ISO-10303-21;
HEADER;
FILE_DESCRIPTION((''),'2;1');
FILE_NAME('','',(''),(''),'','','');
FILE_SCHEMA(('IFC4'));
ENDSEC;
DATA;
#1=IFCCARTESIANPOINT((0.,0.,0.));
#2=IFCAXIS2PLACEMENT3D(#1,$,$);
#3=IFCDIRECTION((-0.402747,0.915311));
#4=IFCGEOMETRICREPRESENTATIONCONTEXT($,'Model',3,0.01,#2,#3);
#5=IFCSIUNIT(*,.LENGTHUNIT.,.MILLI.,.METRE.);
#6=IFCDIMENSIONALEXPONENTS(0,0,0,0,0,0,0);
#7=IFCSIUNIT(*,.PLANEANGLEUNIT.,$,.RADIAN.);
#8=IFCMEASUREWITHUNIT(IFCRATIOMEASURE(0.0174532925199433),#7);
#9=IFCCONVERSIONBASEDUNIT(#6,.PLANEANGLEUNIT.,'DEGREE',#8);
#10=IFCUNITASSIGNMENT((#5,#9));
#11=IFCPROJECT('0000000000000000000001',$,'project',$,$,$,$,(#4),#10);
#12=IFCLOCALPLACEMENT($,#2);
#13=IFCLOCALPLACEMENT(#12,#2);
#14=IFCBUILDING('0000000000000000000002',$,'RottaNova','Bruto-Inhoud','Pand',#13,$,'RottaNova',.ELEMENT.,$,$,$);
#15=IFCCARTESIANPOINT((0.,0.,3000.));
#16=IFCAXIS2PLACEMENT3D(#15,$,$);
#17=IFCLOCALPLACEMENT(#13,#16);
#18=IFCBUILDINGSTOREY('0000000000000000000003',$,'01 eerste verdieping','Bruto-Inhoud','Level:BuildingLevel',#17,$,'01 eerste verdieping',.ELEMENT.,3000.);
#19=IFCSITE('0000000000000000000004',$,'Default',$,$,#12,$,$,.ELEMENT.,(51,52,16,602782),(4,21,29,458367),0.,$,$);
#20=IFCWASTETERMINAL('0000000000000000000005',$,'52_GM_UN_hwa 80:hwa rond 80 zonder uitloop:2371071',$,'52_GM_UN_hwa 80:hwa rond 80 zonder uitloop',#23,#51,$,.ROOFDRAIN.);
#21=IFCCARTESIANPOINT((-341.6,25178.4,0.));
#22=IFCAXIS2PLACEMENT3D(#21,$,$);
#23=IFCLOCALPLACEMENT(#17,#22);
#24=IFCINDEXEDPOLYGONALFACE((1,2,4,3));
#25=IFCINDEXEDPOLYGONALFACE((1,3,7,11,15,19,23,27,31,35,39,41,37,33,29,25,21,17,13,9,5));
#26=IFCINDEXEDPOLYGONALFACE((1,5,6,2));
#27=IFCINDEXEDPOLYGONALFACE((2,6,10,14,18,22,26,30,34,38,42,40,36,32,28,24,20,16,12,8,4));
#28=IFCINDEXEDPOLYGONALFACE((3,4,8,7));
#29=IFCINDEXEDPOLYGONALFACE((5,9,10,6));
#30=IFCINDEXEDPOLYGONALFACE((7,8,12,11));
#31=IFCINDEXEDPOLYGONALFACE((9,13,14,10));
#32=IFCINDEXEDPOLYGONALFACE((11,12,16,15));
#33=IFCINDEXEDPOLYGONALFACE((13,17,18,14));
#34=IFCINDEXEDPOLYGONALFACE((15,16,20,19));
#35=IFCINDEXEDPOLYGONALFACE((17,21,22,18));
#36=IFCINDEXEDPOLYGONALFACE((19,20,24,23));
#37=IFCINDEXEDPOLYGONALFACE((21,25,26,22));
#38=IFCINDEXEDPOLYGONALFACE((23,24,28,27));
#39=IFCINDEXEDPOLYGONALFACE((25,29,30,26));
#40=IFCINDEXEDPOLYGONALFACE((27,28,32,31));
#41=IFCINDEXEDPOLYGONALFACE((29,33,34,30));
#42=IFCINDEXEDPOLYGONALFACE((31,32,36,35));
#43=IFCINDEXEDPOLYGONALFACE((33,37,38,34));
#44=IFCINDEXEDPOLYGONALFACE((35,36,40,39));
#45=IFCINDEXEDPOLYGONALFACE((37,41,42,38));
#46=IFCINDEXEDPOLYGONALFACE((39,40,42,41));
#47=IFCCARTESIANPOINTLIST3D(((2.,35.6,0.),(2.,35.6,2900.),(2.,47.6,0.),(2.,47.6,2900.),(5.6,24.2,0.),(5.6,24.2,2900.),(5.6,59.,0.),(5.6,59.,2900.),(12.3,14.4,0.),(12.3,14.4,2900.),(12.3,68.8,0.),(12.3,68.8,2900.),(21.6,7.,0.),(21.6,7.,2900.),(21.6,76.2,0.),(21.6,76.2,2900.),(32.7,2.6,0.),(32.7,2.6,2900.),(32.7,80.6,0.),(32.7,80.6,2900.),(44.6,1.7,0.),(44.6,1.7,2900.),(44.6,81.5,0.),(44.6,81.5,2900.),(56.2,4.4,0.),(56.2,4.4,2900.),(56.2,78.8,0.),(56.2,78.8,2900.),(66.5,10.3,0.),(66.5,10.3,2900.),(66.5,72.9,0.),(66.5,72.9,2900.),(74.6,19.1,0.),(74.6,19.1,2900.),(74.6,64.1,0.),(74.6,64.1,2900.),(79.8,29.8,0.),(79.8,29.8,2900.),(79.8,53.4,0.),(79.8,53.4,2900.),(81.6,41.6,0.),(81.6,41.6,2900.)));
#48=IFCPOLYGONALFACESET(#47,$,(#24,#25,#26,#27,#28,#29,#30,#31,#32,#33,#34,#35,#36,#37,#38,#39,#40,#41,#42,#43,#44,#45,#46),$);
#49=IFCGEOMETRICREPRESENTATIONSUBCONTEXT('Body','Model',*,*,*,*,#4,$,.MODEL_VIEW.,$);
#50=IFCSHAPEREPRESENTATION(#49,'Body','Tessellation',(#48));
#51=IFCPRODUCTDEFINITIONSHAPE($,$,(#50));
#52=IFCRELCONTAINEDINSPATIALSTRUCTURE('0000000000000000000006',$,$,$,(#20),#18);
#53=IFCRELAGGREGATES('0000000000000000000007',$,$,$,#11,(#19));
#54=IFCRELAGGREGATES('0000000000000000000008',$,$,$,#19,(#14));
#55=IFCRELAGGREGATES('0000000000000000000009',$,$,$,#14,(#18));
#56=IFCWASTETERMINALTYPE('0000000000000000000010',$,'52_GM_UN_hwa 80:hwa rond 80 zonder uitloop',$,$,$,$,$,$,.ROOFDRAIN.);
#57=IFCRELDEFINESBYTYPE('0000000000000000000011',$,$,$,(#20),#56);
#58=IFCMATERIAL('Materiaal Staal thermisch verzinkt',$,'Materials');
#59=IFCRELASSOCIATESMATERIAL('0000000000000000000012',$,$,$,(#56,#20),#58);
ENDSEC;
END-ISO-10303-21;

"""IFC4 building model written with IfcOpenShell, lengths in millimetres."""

from ifc_helpers import new_model, entity, si_unit, converted_unit, direction, frame, frame_2d, origin, place, context, subcontext, project, spatial, circle, extrude, source, transform, mapped, material, type_object, type_shapes, element, save


model = new_model("IFC4")

# Units and contexts
model_context = context("Model", 3, precision=0.01, world=origin(), true_north=direction((-0.402747, 0.915311)))
body_context = subcontext(model_context, "Body", "Model", "MODEL_VIEW")
ifc_project = project(units=[si_unit("LENGTHUNIT", "METRE", prefix="MILLI"), converted_unit("PLANEANGLEUNIT", "DEGREE", entity("IfcRatioMeasure", 0.0174532925199433), si_unit("PLANEANGLEUNIT", "RADIAN"), dimensions=[0, 0, 0, 0, 0, 0, 0])], contexts=[model_context])

# Site, building, storey
site_placement = place(None, origin())
site = spatial("IfcSite", under=ifc_project, at=site_placement, Name="Default", CompositionType="ELEMENT", RefLatitude=(51, 52, 16, 602782), RefLongitude=(4, 21, 29, 458367), RefElevation=0.0)
building_placement = place(site_placement, origin())
building = spatial("IfcBuilding", under=site, at=building_placement, Name="RottaNova", Description="Bruto-Inhoud", ObjectType="Pand", LongName="RottaNova", CompositionType="ELEMENT")
storey_placement = place(building_placement, frame((0.0, 0.0, 3000.0)))
storey = spatial("IfcBuildingStorey", under=building, at=storey_placement, Name="01 eerste verdieping", Description="Bruto-Inhoud", ObjectType="Level:BuildingLevel", LongName="01 eerste verdieping", CompositionType="ELEMENT", Elevation=3000.0)

# Waste terminal
ifc_material_1 = material(Name="Materiaal Staal thermisch verzinkt", Category="Materials")
waste_terminal_type = type_object("IfcWasteTerminalType", Name="52_GM_UN_hwa 80:hwa rond 80 zonder uitloop", PredefinedType="ROOFDRAIN", material=ifc_material_1)
shared_shape_1 = source(origin(), body_context, "Body", "SweptSolid", [
    extrude(circle(Radius=40.0, at=frame_2d((0.0, 0.0), x_axis=(1.0, 0.0))), frame((41.6, 41.6, 0.0)), (0.0, 0.0, 1.0), 2900.0),
])
type_shapes(waste_terminal_type, [shared_shape_1])
waste_terminal_placement = place(storey_placement, frame((-341.6, 25178.4, 0.0)))
element("IfcWasteTerminal", 1, at=waste_terminal_placement, inside=storey, type_object=waste_terminal_type, material=ifc_material_1, Name="52_GM_UN_hwa 80:hwa rond 80 zonder uitloop:2371071", ObjectType="52_GM_UN_hwa 80:hwa rond 80 zonder uitloop", PredefinedType="ROOFDRAIN", context=body_context, shape_type="MappedRepresentation", body=[
    mapped(shared_shape_1, transform((0.0, 0.0, 0.0), scale=1.0)),
])

save(model, "model.ifc")
